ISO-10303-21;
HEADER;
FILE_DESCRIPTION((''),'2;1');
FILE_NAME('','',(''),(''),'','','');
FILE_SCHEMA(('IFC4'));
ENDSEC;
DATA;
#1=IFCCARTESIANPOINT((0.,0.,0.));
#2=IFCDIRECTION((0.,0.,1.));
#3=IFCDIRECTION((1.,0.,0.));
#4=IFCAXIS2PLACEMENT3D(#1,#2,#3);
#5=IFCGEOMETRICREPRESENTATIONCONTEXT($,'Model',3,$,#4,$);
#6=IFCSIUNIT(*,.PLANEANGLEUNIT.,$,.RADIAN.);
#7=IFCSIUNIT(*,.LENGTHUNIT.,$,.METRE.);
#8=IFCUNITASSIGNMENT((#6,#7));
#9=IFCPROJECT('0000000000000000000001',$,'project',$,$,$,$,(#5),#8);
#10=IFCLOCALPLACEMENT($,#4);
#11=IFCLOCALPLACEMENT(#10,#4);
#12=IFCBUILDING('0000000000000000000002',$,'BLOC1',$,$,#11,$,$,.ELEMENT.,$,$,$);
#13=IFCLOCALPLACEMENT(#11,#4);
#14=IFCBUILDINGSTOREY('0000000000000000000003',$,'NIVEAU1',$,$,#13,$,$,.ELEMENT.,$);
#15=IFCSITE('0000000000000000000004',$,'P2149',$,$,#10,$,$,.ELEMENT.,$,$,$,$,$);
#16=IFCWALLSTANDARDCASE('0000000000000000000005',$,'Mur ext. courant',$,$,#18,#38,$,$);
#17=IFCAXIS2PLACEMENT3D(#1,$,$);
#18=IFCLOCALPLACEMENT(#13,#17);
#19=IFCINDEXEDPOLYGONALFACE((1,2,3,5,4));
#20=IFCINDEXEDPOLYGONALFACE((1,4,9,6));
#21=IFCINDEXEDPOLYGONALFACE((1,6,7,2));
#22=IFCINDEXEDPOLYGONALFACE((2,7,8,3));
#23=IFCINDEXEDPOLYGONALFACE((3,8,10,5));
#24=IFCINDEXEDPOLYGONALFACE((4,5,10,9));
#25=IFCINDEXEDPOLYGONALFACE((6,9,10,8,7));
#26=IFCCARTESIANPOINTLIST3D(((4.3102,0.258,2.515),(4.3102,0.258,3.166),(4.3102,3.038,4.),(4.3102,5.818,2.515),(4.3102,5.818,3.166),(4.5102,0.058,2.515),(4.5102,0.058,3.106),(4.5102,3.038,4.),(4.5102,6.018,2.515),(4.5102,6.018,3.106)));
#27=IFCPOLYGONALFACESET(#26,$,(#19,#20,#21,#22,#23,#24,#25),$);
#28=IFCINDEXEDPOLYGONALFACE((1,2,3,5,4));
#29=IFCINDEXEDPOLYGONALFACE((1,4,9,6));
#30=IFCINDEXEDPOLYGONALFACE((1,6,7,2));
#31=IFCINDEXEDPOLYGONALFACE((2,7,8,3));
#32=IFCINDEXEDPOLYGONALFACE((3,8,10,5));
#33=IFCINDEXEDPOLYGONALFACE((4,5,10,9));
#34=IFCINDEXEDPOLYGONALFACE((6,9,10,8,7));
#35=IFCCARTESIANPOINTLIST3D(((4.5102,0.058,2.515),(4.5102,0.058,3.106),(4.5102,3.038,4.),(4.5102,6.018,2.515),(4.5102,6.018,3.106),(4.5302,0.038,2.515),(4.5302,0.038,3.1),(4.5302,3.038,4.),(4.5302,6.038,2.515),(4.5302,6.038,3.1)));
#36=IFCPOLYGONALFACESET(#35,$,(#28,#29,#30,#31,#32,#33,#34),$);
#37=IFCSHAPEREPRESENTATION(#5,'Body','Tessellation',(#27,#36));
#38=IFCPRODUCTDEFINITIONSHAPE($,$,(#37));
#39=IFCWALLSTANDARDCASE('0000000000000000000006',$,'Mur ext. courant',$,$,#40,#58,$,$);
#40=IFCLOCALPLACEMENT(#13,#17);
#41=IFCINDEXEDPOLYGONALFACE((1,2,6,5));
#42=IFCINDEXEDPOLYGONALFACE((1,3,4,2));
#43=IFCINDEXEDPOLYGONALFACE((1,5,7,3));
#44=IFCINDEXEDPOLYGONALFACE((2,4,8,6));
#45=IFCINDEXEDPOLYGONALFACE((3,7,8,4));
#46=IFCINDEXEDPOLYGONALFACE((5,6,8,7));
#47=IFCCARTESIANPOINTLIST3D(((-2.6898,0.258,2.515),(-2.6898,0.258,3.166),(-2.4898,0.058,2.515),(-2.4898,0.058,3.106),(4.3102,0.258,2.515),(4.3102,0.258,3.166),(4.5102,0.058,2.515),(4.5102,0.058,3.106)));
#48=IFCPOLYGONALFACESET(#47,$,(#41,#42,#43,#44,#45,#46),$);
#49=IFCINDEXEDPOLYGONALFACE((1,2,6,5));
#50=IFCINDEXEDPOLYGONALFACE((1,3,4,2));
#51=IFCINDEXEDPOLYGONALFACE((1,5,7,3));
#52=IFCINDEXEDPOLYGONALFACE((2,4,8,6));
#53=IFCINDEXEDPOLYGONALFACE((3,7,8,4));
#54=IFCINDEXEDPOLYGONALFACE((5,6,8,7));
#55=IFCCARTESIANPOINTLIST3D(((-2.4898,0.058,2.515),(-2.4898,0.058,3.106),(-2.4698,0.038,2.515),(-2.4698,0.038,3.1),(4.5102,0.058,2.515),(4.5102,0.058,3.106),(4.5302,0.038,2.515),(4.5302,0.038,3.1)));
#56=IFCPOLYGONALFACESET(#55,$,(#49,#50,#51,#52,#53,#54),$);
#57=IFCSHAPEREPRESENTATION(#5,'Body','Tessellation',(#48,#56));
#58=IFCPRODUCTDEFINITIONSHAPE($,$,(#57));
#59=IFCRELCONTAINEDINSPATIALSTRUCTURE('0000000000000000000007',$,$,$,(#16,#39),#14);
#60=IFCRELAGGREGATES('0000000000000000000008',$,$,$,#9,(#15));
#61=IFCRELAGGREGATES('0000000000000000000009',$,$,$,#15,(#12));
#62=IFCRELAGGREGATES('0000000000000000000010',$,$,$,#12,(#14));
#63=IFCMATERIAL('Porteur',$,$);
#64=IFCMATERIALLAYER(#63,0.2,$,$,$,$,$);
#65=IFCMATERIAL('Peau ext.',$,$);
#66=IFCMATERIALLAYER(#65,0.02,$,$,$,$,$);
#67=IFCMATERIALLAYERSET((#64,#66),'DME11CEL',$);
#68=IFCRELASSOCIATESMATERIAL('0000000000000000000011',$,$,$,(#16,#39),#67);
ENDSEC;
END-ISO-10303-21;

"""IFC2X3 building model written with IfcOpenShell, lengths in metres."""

from ifc_helpers import new_model, si_unit, point, frame, origin_with_axes, place, context, project, spatial, line_curve, trimmed, segment, composite_curve, outline, extrude, clip, bounded_halfspace, material, layer, layer_set, layer_usage, element, save


model = new_model("IFC2X3")

# Units and contexts
model_context = context("Model", 3, world=origin_with_axes())
ifc_project = project(units=[si_unit("PLANEANGLEUNIT", "RADIAN"), si_unit("LENGTHUNIT", "METRE")], contexts=[model_context])

# Site, building, storey
site_placement = place(None, origin_with_axes())
site = spatial("IfcSite", under=ifc_project, at=site_placement, Name="P2149", CompositionType="ELEMENT")
building_placement = place(site_placement, origin_with_axes())
building = spatial("IfcBuilding", under=site, at=building_placement, Name="BLOC1", CompositionType="ELEMENT")
storey_placement = place(building_placement, origin_with_axes())
storey = spatial("IfcBuildingStorey", under=building, at=storey_placement, Name="NIVEAU1", CompositionType="ELEMENT")

# Walls
ifc_material_1 = material(Name="Porteur")
ifc_layer_1 = layer(ifc_material_1, 0.2)
ifc_material_2 = material(Name="Peau ext.")
ifc_layer_2 = layer(ifc_material_2, 0.02)
ifc_layer_set = layer_set([ifc_layer_1, ifc_layer_2], Name="DME11CEL")
ifc_layer_usage = layer_usage(ifc_layer_set, "AXIS2", "POSITIVE", 0.0)
wall_1_placement = place(storey_placement, frame((4.3102, 5.818, 2.515), z_axis=(0.0, 0.0, 1.0), x_axis=(0.0, -1.0, 0.0)))
element("IfcWallStandardCase", 1, at=wall_1_placement, inside=storey, material=ifc_layer_usage, Name="Mur ext. courant", context=model_context, shape_type="Clipping", body=[
    clip(clip(extrude(outline(composite_curve([segment(trimmed(line_curve((0.0, 0.0), (1.0, 0.0), 5.56), [point((0.0, 0.0))], [point((5.56, 0.0))], True, "CARTESIAN"), True, "CONTINUOUS"), segment(trimmed(line_curve((5.56, 0.0), (0.707107, 0.707107), 0.282843), [point((5.56, 0.0))], [point((5.76, 0.2))], True, "CARTESIAN"), True, "CONTINUOUS"), segment(trimmed(line_curve((5.76, 0.2), (-1.0, 0.0), 5.96), [point((5.76, 0.2))], [point((-0.2, 0.2))], True, "CARTESIAN"), True, "CONTINUOUS"), segment(trimmed(line_curve((-0.2, 0.2), (0.707107, -0.707107), 0.282843), [point((-0.2, 0.2))], [point((0.0, 0.0))], True, "CARTESIAN"), True, "CONTINUOUS")], self_intersect=False)), origin_with_axes(), (0.0, 0.0, 1.0), 1.485), bounded_halfspace(frame((0.0, 0.0, 2.319), z_axis=(0.287348, 0.0, 0.957826), x_axis=(0.0, 1.0, 0.0)), False, frame((2.78, 0.0, 1.485), z_axis=(0.0, 0.0, 1.0), x_axis=(1.0, 0.0, 0.0)), composite_curve([segment(trimmed(line_curve((0.0, 0.0), (1.0, 0.0), 2.78), [point((0.0, 0.0))], [point((2.78, 0.0))], True, "CARTESIAN"), True, "CONTINUOUS"), segment(trimmed(line_curve((2.78, 0.0), (0.707107, 0.707107), 0.282843), [point((2.78, 0.0))], [point((2.98, 0.2))], True, "CARTESIAN"), True, "CONTINUOUS"), segment(trimmed(line_curve((2.98, 0.2), (-1.0, 0.0), 2.98), [point((2.98, 0.2))], [point((0.0, 0.2))], True, "CARTESIAN"), True, "CONTINUOUS"), segment(trimmed(line_curve((0.0, 0.2), (0.0, -1.0), 0.2), [point((0.0, 0.2))], [point((0.0, 0.0))], True, "CARTESIAN"), True, "CONTINUOUS")], self_intersect=False))), bounded_halfspace(frame((0.0, 0.0, 0.651), z_axis=(-0.287348, 0.0, 0.957826), x_axis=(0.0, 1.0, 0.0)), False, frame((0.0, 0.0, 0.651), z_axis=(0.0, 0.0, 1.0), x_axis=(1.0, 0.0, 0.0)), composite_curve([segment(trimmed(line_curve((0.0, 0.0), (1.0, 0.0), 2.78), [point((0.0, 0.0))], [point((2.78, 0.0))], True, "CARTESIAN"), True, "CONTINUOUS"), segment(trimmed(line_curve((2.78, 0.0), (0.0, 1.0), 0.2), [point((2.78, 0.0))], [point((2.78, 0.2))], True, "CARTESIAN"), True, "CONTINUOUS"), segment(trimmed(line_curve((2.78, 0.2), (-1.0, 0.0), 2.98), [point((2.78, 0.2))], [point((-0.2, 0.2))], True, "CARTESIAN"), True, "CONTINUOUS"), segment(trimmed(line_curve((-0.2, 0.2), (0.707107, -0.707107), 0.282843), [point((-0.2, 0.2))], [point((0.0, 0.0))], True, "CARTESIAN"), True, "CONTINUOUS")], self_intersect=False))),
    clip(clip(extrude(outline(composite_curve([segment(trimmed(line_curve((-0.2, 0.2), (1.0, 0.0), 5.96), [point((-0.2, 0.2))], [point((5.76, 0.2))], True, "CARTESIAN"), True, "CONTINUOUS"), segment(trimmed(line_curve((5.76, 0.2), (0.707107, 0.707107), 0.028284), [point((5.76, 0.2))], [point((5.78, 0.22))], True, "CARTESIAN"), True, "CONTINUOUS"), segment(trimmed(line_curve((5.78, 0.22), (-1.0, 0.0), 6.0), [point((5.78, 0.22))], [point((-0.22, 0.22))], True, "CARTESIAN"), True, "CONTINUOUS"), segment(trimmed(line_curve((-0.22, 0.22), (0.707107, -0.707107), 0.028284), [point((-0.22, 0.22))], [point((-0.2, 0.2))], True, "CARTESIAN"), True, "CONTINUOUS")], self_intersect=False)), origin_with_axes(), (0.0, 0.0, 1.0), 1.485), bounded_halfspace(frame((0.0, 0.0, 2.319), z_axis=(0.287348, 0.0, 0.957826), x_axis=(0.0, 1.0, 0.0)), False, frame((2.78, 0.2, 1.485), z_axis=(0.0, 0.0, 1.0), x_axis=(1.0, 0.0, 0.0)), composite_curve([segment(trimmed(line_curve((0.0, 0.0), (1.0, 0.0), 2.98), [point((0.0, 0.0))], [point((2.98, 0.0))], True, "CARTESIAN"), True, "CONTINUOUS"), segment(trimmed(line_curve((2.98, 0.0), (0.707107, 0.707107), 0.028284), [point((2.98, 0.0))], [point((3.0, 0.02))], True, "CARTESIAN"), True, "CONTINUOUS"), segment(trimmed(line_curve((3.0, 0.02), (-1.0, 0.0), 3.0), [point((3.0, 0.02))], [point((0.0, 0.02))], True, "CARTESIAN"), True, "CONTINUOUS"), segment(trimmed(line_curve((0.0, 0.02), (0.0, -1.0), 0.02), [point((0.0, 0.02))], [point((0.0, 0.0))], True, "CARTESIAN"), True, "CONTINUOUS")], self_intersect=False))), bounded_halfspace(frame((0.0, 0.0, 0.651), z_axis=(-0.287348, 0.0, 0.957826), x_axis=(0.0, 1.0, 0.0)), False, frame((-0.2, 0.2, 0.591), z_axis=(0.0, 0.0, 1.0), x_axis=(1.0, 0.0, 0.0)), composite_curve([segment(trimmed(line_curve((0.0, 0.0), (1.0, 0.0), 2.98), [point((0.0, 0.0))], [point((2.98, 0.0))], True, "CARTESIAN"), True, "CONTINUOUS"), segment(trimmed(line_curve((2.98, 0.0), (0.0, 1.0), 0.02), [point((2.98, 0.0))], [point((2.98, 0.02))], True, "CARTESIAN"), True, "CONTINUOUS"), segment(trimmed(line_curve((2.98, 0.02), (-1.0, 0.0), 3.0), [point((2.98, 0.02))], [point((-0.02, 0.02))], True, "CARTESIAN"), True, "CONTINUOUS"), segment(trimmed(line_curve((-0.02, 0.02), (0.707107, -0.707107), 0.028284), [point((-0.02, 0.02))], [point((0.0, 0.0))], True, "CARTESIAN"), True, "CONTINUOUS")], self_intersect=False))),
])
wall_2_placement = place(storey_placement, frame((4.3102, 0.258, 2.515), z_axis=(0.0, 0.0, 1.0), x_axis=(-1.0, 0.0, 0.0)))
element("IfcWallStandardCase", 2, at=wall_2_placement, inside=storey, material=ifc_layer_usage, Name="Mur ext. courant", context=model_context, shape_type="Clipping", body=[
    clip(extrude(outline(composite_curve([segment(trimmed(line_curve((0.0, 0.0), (1.0, 0.0), 7.0), [point((0.0, 0.0))], [point((7.0, 0.0))], True, "CARTESIAN"), True, "CONTINUOUS"), segment(trimmed(line_curve((7.0, 0.0), (-0.707107, 0.707107), 0.282843), [point((7.0, 0.0))], [point((6.8, 0.2))], True, "CARTESIAN"), True, "CONTINUOUS"), segment(trimmed(line_curve((6.8, 0.2), (-1.0, 0.0), 7.0), [point((6.8, 0.2))], [point((-0.2, 0.2))], True, "CARTESIAN"), True, "CONTINUOUS"), segment(trimmed(line_curve((-0.2, 0.2), (0.707107, -0.707107), 0.282843), [point((-0.2, 0.2))], [point((0.0, 0.0))], True, "CARTESIAN"), True, "CONTINUOUS")], self_intersect=False)), origin_with_axes(), (0.0, 0.0, 1.0), 0.651), bounded_halfspace(frame((0.0, 0.0, 0.651), z_axis=(0.0, 0.287348, 0.957826), x_axis=(0.0, 0.957826, -0.287348)), False, frame((0.0, 0.0, 0.651), z_axis=(0.0, 0.0, 1.0), x_axis=(1.0, 0.0, 0.0)), composite_curve([segment(trimmed(line_curve((0.0, 0.0), (1.0, 0.0), 7.0), [point((0.0, 0.0))], [point((7.0, 0.0))], True, "CARTESIAN"), True, "CONTINUOUS"), segment(trimmed(line_curve((7.0, 0.0), (-0.707107, 0.707107), 0.282843), [point((7.0, 0.0))], [point((6.8, 0.2))], True, "CARTESIAN"), True, "CONTINUOUS"), segment(trimmed(line_curve((6.8, 0.2), (-1.0, 0.0), 7.0), [point((6.8, 0.2))], [point((-0.2, 0.2))], True, "CARTESIAN"), True, "CONTINUOUS"), segment(trimmed(line_curve((-0.2, 0.2), (0.707107, -0.707107), 0.282843), [point((-0.2, 0.2))], [point((0.0, 0.0))], True, "CARTESIAN"), True, "CONTINUOUS")], self_intersect=False))),
    clip(extrude(outline(composite_curve([segment(trimmed(line_curve((-0.2, 0.2), (1.0, 0.0), 7.0), [point((-0.2, 0.2))], [point((6.8, 0.2))], True, "CARTESIAN"), True, "CONTINUOUS"), segment(trimmed(line_curve((6.8, 0.2), (-0.707107, 0.707107), 0.028284), [point((6.8, 0.2))], [point((6.78, 0.22))], True, "CARTESIAN"), True, "CONTINUOUS"), segment(trimmed(line_curve((6.78, 0.22), (-1.0, 0.0), 7.0), [point((6.78, 0.22))], [point((-0.22, 0.22))], True, "CARTESIAN"), True, "CONTINUOUS"), segment(trimmed(line_curve((-0.22, 0.22), (0.707107, -0.707107), 0.028284), [point((-0.22, 0.22))], [point((-0.2, 0.2))], True, "CARTESIAN"), True, "CONTINUOUS")], self_intersect=False)), origin_with_axes(), (0.0, 0.0, 1.0), 0.651), bounded_halfspace(frame((0.0, 0.0, 0.651), z_axis=(0.0, 0.287348, 0.957826), x_axis=(0.0, 0.957826, -0.287348)), False, frame((-0.2, 0.2, 0.591), z_axis=(0.0, 0.0, 1.0), x_axis=(1.0, 0.0, 0.0)), composite_curve([segment(trimmed(line_curve((0.0, 0.0), (1.0, 0.0), 7.0), [point((0.0, 0.0))], [point((7.0, 0.0))], True, "CARTESIAN"), True, "CONTINUOUS"), segment(trimmed(line_curve((7.0, 0.0), (-0.707107, 0.707107), 0.028284), [point((7.0, 0.0))], [point((6.98, 0.02))], True, "CARTESIAN"), True, "CONTINUOUS"), segment(trimmed(line_curve((6.98, 0.02), (-1.0, 0.0), 7.0), [point((6.98, 0.02))], [point((-0.02, 0.02))], True, "CARTESIAN"), True, "CONTINUOUS"), segment(trimmed(line_curve((-0.02, 0.02), (0.707107, -0.707107), 0.028284), [point((-0.02, 0.02))], [point((0.0, 0.0))], True, "CARTESIAN"), True, "CONTINUOUS")], self_intersect=False))),
])

save(model, "model.ifc")
